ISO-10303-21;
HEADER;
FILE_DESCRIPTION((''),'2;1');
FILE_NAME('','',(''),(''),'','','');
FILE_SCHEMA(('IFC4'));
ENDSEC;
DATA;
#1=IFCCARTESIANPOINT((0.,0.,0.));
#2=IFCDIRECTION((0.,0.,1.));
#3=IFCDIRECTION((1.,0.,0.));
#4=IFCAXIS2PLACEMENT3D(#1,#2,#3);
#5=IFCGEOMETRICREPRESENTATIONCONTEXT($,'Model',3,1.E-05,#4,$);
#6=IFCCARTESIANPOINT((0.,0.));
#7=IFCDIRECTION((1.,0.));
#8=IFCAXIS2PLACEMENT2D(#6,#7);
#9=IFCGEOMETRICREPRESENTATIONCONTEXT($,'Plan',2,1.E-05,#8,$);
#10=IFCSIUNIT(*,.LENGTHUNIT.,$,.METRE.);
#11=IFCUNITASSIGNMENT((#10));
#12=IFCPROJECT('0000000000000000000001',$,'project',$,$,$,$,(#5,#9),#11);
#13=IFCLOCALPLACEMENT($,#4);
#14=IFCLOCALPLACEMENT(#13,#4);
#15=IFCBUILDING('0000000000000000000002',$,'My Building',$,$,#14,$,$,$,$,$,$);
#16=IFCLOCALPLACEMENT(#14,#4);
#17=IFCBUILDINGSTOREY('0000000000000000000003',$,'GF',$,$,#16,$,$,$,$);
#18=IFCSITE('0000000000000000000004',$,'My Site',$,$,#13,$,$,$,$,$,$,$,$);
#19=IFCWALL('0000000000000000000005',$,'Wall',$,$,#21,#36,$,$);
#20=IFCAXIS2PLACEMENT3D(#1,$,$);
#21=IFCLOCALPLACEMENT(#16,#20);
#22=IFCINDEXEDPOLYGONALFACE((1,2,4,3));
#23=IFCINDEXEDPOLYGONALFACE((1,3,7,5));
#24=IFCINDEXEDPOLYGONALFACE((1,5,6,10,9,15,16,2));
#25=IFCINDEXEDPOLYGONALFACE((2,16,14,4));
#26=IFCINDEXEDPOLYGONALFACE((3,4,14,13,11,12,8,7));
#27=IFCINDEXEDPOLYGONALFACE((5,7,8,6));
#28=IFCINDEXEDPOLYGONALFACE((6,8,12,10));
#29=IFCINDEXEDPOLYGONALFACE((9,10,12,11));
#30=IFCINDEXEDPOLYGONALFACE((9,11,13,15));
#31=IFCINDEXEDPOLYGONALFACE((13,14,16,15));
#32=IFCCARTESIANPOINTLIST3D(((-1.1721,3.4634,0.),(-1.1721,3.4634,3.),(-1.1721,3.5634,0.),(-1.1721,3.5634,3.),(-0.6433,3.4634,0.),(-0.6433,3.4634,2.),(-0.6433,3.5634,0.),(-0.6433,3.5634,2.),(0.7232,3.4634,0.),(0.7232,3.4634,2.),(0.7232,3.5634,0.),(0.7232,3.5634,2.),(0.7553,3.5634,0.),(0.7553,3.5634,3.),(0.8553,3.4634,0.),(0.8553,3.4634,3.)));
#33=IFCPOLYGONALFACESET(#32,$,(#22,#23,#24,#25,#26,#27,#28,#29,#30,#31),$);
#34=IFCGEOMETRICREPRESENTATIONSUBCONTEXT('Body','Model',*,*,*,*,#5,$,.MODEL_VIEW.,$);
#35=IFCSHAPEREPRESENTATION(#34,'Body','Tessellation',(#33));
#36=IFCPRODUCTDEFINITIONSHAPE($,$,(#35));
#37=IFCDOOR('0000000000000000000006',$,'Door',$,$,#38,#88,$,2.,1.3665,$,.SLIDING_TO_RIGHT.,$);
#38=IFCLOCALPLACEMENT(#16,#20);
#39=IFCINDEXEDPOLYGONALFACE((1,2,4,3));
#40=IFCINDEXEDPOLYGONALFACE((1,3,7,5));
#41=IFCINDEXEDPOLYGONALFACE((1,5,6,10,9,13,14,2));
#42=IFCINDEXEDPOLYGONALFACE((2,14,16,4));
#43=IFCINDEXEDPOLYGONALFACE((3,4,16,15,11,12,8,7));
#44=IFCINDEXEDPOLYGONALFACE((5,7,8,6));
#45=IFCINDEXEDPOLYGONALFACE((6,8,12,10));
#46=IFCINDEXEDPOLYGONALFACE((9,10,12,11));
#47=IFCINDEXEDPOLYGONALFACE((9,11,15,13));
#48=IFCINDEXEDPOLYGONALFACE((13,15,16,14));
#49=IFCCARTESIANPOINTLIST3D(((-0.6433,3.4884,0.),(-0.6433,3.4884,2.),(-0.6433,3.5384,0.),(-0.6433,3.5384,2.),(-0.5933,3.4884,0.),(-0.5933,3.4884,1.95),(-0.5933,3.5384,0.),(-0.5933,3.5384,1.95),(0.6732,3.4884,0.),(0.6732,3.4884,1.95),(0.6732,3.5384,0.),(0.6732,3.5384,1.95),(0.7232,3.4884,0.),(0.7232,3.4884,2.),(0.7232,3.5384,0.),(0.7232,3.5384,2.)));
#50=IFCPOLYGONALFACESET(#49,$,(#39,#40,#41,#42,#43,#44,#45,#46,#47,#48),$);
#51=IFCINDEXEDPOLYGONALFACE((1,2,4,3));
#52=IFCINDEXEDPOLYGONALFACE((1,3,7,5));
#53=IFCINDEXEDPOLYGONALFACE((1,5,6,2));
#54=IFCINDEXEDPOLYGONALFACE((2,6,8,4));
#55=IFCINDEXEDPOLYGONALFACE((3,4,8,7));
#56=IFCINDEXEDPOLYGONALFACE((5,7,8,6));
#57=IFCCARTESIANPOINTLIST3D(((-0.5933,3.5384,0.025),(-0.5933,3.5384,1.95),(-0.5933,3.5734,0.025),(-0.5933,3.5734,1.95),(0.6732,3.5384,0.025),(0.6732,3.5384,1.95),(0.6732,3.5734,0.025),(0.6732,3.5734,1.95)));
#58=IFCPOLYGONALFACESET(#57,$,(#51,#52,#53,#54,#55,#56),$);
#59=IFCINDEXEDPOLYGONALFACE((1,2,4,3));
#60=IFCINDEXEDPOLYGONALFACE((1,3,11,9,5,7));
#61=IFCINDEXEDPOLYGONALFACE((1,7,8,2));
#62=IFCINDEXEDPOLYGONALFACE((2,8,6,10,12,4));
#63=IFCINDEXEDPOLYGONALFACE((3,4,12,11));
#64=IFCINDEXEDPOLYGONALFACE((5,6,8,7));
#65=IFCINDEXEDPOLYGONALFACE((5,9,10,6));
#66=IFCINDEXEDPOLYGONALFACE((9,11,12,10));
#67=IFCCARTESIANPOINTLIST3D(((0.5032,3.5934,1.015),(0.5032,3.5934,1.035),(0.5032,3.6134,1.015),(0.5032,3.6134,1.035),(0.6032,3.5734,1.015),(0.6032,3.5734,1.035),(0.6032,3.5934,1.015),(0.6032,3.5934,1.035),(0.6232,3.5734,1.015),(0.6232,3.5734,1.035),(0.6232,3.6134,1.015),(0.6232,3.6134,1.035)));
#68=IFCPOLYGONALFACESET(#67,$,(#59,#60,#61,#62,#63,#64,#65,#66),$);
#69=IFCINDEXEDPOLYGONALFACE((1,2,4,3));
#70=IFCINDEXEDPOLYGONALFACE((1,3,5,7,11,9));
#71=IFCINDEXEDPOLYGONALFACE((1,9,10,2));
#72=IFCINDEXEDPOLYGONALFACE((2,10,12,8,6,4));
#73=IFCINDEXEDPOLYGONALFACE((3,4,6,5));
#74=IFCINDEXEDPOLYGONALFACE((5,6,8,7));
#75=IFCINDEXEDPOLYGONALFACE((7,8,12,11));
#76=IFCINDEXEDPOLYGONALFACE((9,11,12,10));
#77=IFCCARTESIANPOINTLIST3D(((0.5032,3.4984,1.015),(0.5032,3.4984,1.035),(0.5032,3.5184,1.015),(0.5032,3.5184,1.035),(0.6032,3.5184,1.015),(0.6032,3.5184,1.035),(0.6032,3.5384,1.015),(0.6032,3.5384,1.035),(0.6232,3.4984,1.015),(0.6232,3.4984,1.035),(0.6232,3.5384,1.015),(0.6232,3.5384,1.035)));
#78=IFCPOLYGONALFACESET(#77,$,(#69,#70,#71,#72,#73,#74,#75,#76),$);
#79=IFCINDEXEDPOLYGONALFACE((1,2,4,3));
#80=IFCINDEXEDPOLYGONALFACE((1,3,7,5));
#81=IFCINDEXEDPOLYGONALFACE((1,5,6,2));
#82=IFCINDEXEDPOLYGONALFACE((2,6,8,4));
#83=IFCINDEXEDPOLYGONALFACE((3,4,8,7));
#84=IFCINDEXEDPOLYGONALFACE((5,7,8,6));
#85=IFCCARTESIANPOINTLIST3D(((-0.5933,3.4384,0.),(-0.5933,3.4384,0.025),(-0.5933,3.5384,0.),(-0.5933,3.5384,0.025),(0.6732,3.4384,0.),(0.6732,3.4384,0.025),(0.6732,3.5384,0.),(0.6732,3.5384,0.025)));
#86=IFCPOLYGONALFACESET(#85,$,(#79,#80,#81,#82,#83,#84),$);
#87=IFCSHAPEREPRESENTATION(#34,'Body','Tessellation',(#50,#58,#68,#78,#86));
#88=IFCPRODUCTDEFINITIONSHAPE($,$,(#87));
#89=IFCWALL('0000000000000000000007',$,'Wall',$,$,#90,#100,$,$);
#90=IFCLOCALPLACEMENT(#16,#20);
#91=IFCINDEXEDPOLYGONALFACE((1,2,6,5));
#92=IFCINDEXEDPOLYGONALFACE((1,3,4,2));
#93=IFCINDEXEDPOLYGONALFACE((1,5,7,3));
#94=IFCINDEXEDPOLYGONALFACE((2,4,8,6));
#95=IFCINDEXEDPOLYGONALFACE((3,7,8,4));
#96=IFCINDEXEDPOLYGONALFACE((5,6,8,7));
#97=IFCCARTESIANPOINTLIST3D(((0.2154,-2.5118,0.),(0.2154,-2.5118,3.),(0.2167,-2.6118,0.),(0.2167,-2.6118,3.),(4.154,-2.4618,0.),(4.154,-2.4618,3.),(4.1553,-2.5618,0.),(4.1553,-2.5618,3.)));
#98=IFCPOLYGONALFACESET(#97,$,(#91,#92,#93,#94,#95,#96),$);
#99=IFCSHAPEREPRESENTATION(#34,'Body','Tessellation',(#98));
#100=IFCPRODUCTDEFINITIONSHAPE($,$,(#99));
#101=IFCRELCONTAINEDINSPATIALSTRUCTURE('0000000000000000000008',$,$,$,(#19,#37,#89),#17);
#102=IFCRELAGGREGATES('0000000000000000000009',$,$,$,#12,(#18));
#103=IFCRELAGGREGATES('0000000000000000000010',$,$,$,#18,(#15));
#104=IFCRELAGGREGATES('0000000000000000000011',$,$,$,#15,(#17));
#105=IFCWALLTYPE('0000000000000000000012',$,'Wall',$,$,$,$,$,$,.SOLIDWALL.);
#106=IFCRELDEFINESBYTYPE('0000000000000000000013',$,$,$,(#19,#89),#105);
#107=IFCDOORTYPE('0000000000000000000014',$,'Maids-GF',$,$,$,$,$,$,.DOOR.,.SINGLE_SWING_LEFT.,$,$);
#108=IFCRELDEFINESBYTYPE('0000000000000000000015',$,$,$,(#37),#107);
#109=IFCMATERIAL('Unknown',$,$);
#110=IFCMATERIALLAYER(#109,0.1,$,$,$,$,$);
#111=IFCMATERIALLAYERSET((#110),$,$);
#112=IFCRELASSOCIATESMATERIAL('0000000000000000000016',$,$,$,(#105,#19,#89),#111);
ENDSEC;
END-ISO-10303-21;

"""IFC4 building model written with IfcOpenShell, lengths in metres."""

from ifc_helpers import new_model, entity, si_unit, frame, origin_with_axes, origin_2d_with_axis, place, context, subcontext, project, spatial, line, indexed_curve, outline, extrude, shape, source, transform, mapped, material, layer, layer_set, layer_usage, type_object, type_shapes, element, fill, save


model = new_model("IFC4")

# Units and contexts
model_context = context("Model", 3, precision=1e-05, world=origin_with_axes())
plan_context = context("Plan", 2, precision=1e-05, world=origin_2d_with_axis())
body_context_1 = subcontext(model_context, "Body", "Model", "MODEL_VIEW")
body_context_2 = subcontext(plan_context, "Body", "Plan", "PLAN_VIEW")
ifc_project = project(units=[si_unit("LENGTHUNIT", "METRE")], contexts=[model_context, plan_context])

# Site, building, storey
site_placement = place(None, origin_with_axes())
site = spatial("IfcSite", under=ifc_project, at=site_placement, Name="My Site")
building_placement = place(site_placement, origin_with_axes())
building = spatial("IfcBuilding", under=site, at=building_placement, Name="My Building")
storey_placement = place(building_placement, origin_with_axes())
storey = spatial("IfcBuildingStorey", under=building, at=storey_placement, Name="GF")

# Shared definitions
ifc_material_1 = material(Name="Unknown")

# Shared definitions
ifc_layer_1 = layer(ifc_material_1, 0.1)
ifc_layer_set_1 = layer_set([ifc_layer_1])
wall_type = type_object("IfcWallType", Name="Wall", PredefinedType="SOLIDWALL", material=ifc_layer_set_1)

# Wall, opening, door
ifc_layer_usage_1 = layer_usage(ifc_layer_set_1, "AXIS2", "POSITIVE", 0.0)
wall_1_placement = place(storey_placement, frame((0.7553, 3.5634, 0.0), z_axis=(0.0, 0.0, 1.0), x_axis=(-1.0, 0.0, 0.0)))
wall_1 = element("IfcWall", 1, at=wall_1_placement, inside=storey, type_object=wall_type, material=ifc_layer_usage_1, Name="Wall", context=body_context_1, shape_type="SweptSolid", body=[
    extrude(outline(indexed_curve([(0.0, 0.0), (-0.1, 0.1), (1.9273, 0.1), (1.9273, 0.0)], segments=[line(1, 2, 3, 4, 1)])), origin_with_axes(), (0.0, 0.0, 1.0), 3.0),
])
shared_shape_1 = source(origin_with_axes(), body_context_1, "Body", "SweptSolid", [
    extrude(outline(indexed_curve([(0.0, 0.0), (1.3665, 0.0), (1.3665, 2.0), (0.0, 2.0)], segments=[line(1, 2, 3, 4, 1)])), frame((0.0, -0.6, 0.0), z_axis=(0.0, -1.0, 0.0), x_axis=(1.0, 0.0, 0.0)), (0.0, 0.0, -1.0), 1.2),
])
opening_1_placement = place(wall_1_placement, frame((0.0321, 0.025, 0.0), z_axis=(0.0, 0.0, 1.0), x_axis=(1.0, 0.0, 0.0)))
opening_1 = element("IfcOpeningElement", 2, at=opening_1_placement, cuts=wall_1, PredefinedType="OPENING", context=body_context_1, shape_type="MappedRepresentation", body=[
    mapped(shared_shape_1, transform((0.0, 0.0, 0.0), x_axis=(1.0, 0.0, 0.0), y_axis=(0.0, 1.0, 0.0), z_axis=(0.0, 0.0, 1.0), scale=1.0)),
])
door_type_1 = type_object("IfcDoorType", Name="Maids-GF", OperationType="SINGLE_SWING_LEFT", PredefinedType="DOOR")
shared_shape_2 = source(origin_with_axes(), body_context_1, "Body", "SweptSolid", [
    extrude(outline(indexed_curve([(0.0, 0.0), (0.0, 2.0), (1.3665, 2.0), (1.3665, 0.0), (1.3165, 0.0), (1.3165, 1.95), (0.05, 1.95), (0.05, 0.0)], segments=[line(1, 2, 3, 4, 5, 6, 7, 8, 1)])), frame((0.0, 0.0, 0.0), z_axis=(0.0, -1.0, 0.0), x_axis=(1.0, 0.0, 0.0)), (0.0, 0.0, -1.0), 0.05),
    extrude(outline(indexed_curve([(0.0, 0.0), (1.2665, 0.0), (1.2665, 0.035), (0.0, 0.035)], segments=[line(1, 2, 3, 4, 1)])), frame((0.05, -0.035, 0.025), z_axis=(0.0, 0.0, 1.0), x_axis=(1.0, 0.0, 0.0)), (0.0, 0.0, 1.0), 1.925),
    extrude(outline(indexed_curve([(0.0, 0.0), (0.0, -0.04), (0.12, -0.04), (0.12, -0.02), (0.02, -0.02), (0.02, 0.0)], segments=[line(1, 2, 3, 4, 5, 6, 1)])), frame((0.1, -0.035, 1.015), z_axis=(0.0, 0.0, 1.0), x_axis=(1.0, 0.0, 0.0)), (0.0, 0.0, 1.0), 0.02),
    extrude(outline(indexed_curve([(0.0, 0.0), (0.0, 0.04), (0.12, 0.04), (0.12, 0.02), (0.02, 0.02), (0.02, 0.0)], segments=[line(1, 2, 3, 4, 5, 6, 1)])), frame((0.1, 0.0, 1.015), z_axis=(0.0, 0.0, 1.0), x_axis=(1.0, 0.0, 0.0)), (0.0, 0.0, 1.0), 0.02),
    extrude(outline(indexed_curve([(0.0, 0.0), (1.2665, 0.0), (1.2665, 0.1), (0.0, 0.1)], segments=[line(1, 2, 3, 4, 1)])), frame((0.05, 0.0, 0.0), z_axis=(0.0, 0.0, 1.0), x_axis=(1.0, 0.0, 0.0)), (0.0, 0.0, 1.0), 0.025),
])
shared_shape_3 = source(origin_with_axes(), body_context_2, "Body", "Curve2D", [
    entity("IfcIndexedPolyCurve", entity("IfcCartesianPointList2D", [[0.0, 0.0], [0.05, 0.0], [0.05, 0.05], [0.0, 0.05]]), [entity("IfcLineIndex", [1, 2, 3, 4, 1])]),
    entity("IfcIndexedPolyCurve", entity("IfcCartesianPointList2D", [[1.3665, 0.0], [1.3165, 0.0], [1.3165, 0.05], [1.3665, 0.05]]), [entity("IfcLineIndex", [1, 2, 3, 4, 1])]),
    entity("IfcIndexedPolyCurve", entity("IfcCartesianPointList2D", [[1.9498, -0.035], [0.6833, -0.035], [0.6833, 0.0], [1.9498, 0.0]]), [entity("IfcLineIndex", [1, 2, 3, 4, 1])]),
])
type_shapes(door_type_1, [shared_shape_2, shared_shape_3])
door_1_placement = place(opening_1_placement, frame((0.0, 0.0, 0.0), z_axis=(0.0, 0.0, 1.0), x_axis=(1.0, 0.0, 0.0)))
door_1 = element("IfcDoor", 3, at=door_1_placement, inside=storey, type_object=door_type_1, Name="Door", OperationType="SLIDING_TO_RIGHT", OverallHeight=2.0, OverallWidth=1.3665, shapes=[
    shape(body_context_1, "Body", "MappedRepresentation", [mapped(shared_shape_2, transform((0.0, 0.0, 0.0), x_axis=(1.0, 0.0, 0.0), y_axis=(0.0, 1.0, 0.0), z_axis=(0.0, 0.0, 1.0), scale=1.0))]),
    shape(body_context_2, "Body", "MappedRepresentation", [mapped(shared_shape_3, transform((0.0, 0.0, 0.0), x_axis=(1.0, 0.0, 0.0), y_axis=(0.0, 1.0, 0.0), z_axis=(0.0, 0.0, 1.0), scale=1.0))]),
])
fill(opening_1, door_1)

# Wall
ifc_layer_usage_2 = layer_usage(ifc_layer_set_1, "AXIS2", "POSITIVE", 0.0)
wall_2_placement = place(storey_placement, frame((0.2167, -2.6118, 0.0), z_axis=(0.0, 0.0, 1.0), x_axis=(0.999919, 0.012694, 0.0)))
element("IfcWall", 4, at=wall_2_placement, inside=storey, type_object=wall_type, material=ifc_layer_usage_2, Name="Wall", context=body_context_1, shape_type="SweptSolid", body=[
    extrude(outline(indexed_curve([(0.0, 0.0), (0.0, 0.1), (3.939, 0.1), (3.939, 0.0)], segments=[line(1, 2, 3, 4, 1)])), origin_with_axes(), (0.0, 0.0, 1.0), 3.0),
])

save(model, "model.ifc")
